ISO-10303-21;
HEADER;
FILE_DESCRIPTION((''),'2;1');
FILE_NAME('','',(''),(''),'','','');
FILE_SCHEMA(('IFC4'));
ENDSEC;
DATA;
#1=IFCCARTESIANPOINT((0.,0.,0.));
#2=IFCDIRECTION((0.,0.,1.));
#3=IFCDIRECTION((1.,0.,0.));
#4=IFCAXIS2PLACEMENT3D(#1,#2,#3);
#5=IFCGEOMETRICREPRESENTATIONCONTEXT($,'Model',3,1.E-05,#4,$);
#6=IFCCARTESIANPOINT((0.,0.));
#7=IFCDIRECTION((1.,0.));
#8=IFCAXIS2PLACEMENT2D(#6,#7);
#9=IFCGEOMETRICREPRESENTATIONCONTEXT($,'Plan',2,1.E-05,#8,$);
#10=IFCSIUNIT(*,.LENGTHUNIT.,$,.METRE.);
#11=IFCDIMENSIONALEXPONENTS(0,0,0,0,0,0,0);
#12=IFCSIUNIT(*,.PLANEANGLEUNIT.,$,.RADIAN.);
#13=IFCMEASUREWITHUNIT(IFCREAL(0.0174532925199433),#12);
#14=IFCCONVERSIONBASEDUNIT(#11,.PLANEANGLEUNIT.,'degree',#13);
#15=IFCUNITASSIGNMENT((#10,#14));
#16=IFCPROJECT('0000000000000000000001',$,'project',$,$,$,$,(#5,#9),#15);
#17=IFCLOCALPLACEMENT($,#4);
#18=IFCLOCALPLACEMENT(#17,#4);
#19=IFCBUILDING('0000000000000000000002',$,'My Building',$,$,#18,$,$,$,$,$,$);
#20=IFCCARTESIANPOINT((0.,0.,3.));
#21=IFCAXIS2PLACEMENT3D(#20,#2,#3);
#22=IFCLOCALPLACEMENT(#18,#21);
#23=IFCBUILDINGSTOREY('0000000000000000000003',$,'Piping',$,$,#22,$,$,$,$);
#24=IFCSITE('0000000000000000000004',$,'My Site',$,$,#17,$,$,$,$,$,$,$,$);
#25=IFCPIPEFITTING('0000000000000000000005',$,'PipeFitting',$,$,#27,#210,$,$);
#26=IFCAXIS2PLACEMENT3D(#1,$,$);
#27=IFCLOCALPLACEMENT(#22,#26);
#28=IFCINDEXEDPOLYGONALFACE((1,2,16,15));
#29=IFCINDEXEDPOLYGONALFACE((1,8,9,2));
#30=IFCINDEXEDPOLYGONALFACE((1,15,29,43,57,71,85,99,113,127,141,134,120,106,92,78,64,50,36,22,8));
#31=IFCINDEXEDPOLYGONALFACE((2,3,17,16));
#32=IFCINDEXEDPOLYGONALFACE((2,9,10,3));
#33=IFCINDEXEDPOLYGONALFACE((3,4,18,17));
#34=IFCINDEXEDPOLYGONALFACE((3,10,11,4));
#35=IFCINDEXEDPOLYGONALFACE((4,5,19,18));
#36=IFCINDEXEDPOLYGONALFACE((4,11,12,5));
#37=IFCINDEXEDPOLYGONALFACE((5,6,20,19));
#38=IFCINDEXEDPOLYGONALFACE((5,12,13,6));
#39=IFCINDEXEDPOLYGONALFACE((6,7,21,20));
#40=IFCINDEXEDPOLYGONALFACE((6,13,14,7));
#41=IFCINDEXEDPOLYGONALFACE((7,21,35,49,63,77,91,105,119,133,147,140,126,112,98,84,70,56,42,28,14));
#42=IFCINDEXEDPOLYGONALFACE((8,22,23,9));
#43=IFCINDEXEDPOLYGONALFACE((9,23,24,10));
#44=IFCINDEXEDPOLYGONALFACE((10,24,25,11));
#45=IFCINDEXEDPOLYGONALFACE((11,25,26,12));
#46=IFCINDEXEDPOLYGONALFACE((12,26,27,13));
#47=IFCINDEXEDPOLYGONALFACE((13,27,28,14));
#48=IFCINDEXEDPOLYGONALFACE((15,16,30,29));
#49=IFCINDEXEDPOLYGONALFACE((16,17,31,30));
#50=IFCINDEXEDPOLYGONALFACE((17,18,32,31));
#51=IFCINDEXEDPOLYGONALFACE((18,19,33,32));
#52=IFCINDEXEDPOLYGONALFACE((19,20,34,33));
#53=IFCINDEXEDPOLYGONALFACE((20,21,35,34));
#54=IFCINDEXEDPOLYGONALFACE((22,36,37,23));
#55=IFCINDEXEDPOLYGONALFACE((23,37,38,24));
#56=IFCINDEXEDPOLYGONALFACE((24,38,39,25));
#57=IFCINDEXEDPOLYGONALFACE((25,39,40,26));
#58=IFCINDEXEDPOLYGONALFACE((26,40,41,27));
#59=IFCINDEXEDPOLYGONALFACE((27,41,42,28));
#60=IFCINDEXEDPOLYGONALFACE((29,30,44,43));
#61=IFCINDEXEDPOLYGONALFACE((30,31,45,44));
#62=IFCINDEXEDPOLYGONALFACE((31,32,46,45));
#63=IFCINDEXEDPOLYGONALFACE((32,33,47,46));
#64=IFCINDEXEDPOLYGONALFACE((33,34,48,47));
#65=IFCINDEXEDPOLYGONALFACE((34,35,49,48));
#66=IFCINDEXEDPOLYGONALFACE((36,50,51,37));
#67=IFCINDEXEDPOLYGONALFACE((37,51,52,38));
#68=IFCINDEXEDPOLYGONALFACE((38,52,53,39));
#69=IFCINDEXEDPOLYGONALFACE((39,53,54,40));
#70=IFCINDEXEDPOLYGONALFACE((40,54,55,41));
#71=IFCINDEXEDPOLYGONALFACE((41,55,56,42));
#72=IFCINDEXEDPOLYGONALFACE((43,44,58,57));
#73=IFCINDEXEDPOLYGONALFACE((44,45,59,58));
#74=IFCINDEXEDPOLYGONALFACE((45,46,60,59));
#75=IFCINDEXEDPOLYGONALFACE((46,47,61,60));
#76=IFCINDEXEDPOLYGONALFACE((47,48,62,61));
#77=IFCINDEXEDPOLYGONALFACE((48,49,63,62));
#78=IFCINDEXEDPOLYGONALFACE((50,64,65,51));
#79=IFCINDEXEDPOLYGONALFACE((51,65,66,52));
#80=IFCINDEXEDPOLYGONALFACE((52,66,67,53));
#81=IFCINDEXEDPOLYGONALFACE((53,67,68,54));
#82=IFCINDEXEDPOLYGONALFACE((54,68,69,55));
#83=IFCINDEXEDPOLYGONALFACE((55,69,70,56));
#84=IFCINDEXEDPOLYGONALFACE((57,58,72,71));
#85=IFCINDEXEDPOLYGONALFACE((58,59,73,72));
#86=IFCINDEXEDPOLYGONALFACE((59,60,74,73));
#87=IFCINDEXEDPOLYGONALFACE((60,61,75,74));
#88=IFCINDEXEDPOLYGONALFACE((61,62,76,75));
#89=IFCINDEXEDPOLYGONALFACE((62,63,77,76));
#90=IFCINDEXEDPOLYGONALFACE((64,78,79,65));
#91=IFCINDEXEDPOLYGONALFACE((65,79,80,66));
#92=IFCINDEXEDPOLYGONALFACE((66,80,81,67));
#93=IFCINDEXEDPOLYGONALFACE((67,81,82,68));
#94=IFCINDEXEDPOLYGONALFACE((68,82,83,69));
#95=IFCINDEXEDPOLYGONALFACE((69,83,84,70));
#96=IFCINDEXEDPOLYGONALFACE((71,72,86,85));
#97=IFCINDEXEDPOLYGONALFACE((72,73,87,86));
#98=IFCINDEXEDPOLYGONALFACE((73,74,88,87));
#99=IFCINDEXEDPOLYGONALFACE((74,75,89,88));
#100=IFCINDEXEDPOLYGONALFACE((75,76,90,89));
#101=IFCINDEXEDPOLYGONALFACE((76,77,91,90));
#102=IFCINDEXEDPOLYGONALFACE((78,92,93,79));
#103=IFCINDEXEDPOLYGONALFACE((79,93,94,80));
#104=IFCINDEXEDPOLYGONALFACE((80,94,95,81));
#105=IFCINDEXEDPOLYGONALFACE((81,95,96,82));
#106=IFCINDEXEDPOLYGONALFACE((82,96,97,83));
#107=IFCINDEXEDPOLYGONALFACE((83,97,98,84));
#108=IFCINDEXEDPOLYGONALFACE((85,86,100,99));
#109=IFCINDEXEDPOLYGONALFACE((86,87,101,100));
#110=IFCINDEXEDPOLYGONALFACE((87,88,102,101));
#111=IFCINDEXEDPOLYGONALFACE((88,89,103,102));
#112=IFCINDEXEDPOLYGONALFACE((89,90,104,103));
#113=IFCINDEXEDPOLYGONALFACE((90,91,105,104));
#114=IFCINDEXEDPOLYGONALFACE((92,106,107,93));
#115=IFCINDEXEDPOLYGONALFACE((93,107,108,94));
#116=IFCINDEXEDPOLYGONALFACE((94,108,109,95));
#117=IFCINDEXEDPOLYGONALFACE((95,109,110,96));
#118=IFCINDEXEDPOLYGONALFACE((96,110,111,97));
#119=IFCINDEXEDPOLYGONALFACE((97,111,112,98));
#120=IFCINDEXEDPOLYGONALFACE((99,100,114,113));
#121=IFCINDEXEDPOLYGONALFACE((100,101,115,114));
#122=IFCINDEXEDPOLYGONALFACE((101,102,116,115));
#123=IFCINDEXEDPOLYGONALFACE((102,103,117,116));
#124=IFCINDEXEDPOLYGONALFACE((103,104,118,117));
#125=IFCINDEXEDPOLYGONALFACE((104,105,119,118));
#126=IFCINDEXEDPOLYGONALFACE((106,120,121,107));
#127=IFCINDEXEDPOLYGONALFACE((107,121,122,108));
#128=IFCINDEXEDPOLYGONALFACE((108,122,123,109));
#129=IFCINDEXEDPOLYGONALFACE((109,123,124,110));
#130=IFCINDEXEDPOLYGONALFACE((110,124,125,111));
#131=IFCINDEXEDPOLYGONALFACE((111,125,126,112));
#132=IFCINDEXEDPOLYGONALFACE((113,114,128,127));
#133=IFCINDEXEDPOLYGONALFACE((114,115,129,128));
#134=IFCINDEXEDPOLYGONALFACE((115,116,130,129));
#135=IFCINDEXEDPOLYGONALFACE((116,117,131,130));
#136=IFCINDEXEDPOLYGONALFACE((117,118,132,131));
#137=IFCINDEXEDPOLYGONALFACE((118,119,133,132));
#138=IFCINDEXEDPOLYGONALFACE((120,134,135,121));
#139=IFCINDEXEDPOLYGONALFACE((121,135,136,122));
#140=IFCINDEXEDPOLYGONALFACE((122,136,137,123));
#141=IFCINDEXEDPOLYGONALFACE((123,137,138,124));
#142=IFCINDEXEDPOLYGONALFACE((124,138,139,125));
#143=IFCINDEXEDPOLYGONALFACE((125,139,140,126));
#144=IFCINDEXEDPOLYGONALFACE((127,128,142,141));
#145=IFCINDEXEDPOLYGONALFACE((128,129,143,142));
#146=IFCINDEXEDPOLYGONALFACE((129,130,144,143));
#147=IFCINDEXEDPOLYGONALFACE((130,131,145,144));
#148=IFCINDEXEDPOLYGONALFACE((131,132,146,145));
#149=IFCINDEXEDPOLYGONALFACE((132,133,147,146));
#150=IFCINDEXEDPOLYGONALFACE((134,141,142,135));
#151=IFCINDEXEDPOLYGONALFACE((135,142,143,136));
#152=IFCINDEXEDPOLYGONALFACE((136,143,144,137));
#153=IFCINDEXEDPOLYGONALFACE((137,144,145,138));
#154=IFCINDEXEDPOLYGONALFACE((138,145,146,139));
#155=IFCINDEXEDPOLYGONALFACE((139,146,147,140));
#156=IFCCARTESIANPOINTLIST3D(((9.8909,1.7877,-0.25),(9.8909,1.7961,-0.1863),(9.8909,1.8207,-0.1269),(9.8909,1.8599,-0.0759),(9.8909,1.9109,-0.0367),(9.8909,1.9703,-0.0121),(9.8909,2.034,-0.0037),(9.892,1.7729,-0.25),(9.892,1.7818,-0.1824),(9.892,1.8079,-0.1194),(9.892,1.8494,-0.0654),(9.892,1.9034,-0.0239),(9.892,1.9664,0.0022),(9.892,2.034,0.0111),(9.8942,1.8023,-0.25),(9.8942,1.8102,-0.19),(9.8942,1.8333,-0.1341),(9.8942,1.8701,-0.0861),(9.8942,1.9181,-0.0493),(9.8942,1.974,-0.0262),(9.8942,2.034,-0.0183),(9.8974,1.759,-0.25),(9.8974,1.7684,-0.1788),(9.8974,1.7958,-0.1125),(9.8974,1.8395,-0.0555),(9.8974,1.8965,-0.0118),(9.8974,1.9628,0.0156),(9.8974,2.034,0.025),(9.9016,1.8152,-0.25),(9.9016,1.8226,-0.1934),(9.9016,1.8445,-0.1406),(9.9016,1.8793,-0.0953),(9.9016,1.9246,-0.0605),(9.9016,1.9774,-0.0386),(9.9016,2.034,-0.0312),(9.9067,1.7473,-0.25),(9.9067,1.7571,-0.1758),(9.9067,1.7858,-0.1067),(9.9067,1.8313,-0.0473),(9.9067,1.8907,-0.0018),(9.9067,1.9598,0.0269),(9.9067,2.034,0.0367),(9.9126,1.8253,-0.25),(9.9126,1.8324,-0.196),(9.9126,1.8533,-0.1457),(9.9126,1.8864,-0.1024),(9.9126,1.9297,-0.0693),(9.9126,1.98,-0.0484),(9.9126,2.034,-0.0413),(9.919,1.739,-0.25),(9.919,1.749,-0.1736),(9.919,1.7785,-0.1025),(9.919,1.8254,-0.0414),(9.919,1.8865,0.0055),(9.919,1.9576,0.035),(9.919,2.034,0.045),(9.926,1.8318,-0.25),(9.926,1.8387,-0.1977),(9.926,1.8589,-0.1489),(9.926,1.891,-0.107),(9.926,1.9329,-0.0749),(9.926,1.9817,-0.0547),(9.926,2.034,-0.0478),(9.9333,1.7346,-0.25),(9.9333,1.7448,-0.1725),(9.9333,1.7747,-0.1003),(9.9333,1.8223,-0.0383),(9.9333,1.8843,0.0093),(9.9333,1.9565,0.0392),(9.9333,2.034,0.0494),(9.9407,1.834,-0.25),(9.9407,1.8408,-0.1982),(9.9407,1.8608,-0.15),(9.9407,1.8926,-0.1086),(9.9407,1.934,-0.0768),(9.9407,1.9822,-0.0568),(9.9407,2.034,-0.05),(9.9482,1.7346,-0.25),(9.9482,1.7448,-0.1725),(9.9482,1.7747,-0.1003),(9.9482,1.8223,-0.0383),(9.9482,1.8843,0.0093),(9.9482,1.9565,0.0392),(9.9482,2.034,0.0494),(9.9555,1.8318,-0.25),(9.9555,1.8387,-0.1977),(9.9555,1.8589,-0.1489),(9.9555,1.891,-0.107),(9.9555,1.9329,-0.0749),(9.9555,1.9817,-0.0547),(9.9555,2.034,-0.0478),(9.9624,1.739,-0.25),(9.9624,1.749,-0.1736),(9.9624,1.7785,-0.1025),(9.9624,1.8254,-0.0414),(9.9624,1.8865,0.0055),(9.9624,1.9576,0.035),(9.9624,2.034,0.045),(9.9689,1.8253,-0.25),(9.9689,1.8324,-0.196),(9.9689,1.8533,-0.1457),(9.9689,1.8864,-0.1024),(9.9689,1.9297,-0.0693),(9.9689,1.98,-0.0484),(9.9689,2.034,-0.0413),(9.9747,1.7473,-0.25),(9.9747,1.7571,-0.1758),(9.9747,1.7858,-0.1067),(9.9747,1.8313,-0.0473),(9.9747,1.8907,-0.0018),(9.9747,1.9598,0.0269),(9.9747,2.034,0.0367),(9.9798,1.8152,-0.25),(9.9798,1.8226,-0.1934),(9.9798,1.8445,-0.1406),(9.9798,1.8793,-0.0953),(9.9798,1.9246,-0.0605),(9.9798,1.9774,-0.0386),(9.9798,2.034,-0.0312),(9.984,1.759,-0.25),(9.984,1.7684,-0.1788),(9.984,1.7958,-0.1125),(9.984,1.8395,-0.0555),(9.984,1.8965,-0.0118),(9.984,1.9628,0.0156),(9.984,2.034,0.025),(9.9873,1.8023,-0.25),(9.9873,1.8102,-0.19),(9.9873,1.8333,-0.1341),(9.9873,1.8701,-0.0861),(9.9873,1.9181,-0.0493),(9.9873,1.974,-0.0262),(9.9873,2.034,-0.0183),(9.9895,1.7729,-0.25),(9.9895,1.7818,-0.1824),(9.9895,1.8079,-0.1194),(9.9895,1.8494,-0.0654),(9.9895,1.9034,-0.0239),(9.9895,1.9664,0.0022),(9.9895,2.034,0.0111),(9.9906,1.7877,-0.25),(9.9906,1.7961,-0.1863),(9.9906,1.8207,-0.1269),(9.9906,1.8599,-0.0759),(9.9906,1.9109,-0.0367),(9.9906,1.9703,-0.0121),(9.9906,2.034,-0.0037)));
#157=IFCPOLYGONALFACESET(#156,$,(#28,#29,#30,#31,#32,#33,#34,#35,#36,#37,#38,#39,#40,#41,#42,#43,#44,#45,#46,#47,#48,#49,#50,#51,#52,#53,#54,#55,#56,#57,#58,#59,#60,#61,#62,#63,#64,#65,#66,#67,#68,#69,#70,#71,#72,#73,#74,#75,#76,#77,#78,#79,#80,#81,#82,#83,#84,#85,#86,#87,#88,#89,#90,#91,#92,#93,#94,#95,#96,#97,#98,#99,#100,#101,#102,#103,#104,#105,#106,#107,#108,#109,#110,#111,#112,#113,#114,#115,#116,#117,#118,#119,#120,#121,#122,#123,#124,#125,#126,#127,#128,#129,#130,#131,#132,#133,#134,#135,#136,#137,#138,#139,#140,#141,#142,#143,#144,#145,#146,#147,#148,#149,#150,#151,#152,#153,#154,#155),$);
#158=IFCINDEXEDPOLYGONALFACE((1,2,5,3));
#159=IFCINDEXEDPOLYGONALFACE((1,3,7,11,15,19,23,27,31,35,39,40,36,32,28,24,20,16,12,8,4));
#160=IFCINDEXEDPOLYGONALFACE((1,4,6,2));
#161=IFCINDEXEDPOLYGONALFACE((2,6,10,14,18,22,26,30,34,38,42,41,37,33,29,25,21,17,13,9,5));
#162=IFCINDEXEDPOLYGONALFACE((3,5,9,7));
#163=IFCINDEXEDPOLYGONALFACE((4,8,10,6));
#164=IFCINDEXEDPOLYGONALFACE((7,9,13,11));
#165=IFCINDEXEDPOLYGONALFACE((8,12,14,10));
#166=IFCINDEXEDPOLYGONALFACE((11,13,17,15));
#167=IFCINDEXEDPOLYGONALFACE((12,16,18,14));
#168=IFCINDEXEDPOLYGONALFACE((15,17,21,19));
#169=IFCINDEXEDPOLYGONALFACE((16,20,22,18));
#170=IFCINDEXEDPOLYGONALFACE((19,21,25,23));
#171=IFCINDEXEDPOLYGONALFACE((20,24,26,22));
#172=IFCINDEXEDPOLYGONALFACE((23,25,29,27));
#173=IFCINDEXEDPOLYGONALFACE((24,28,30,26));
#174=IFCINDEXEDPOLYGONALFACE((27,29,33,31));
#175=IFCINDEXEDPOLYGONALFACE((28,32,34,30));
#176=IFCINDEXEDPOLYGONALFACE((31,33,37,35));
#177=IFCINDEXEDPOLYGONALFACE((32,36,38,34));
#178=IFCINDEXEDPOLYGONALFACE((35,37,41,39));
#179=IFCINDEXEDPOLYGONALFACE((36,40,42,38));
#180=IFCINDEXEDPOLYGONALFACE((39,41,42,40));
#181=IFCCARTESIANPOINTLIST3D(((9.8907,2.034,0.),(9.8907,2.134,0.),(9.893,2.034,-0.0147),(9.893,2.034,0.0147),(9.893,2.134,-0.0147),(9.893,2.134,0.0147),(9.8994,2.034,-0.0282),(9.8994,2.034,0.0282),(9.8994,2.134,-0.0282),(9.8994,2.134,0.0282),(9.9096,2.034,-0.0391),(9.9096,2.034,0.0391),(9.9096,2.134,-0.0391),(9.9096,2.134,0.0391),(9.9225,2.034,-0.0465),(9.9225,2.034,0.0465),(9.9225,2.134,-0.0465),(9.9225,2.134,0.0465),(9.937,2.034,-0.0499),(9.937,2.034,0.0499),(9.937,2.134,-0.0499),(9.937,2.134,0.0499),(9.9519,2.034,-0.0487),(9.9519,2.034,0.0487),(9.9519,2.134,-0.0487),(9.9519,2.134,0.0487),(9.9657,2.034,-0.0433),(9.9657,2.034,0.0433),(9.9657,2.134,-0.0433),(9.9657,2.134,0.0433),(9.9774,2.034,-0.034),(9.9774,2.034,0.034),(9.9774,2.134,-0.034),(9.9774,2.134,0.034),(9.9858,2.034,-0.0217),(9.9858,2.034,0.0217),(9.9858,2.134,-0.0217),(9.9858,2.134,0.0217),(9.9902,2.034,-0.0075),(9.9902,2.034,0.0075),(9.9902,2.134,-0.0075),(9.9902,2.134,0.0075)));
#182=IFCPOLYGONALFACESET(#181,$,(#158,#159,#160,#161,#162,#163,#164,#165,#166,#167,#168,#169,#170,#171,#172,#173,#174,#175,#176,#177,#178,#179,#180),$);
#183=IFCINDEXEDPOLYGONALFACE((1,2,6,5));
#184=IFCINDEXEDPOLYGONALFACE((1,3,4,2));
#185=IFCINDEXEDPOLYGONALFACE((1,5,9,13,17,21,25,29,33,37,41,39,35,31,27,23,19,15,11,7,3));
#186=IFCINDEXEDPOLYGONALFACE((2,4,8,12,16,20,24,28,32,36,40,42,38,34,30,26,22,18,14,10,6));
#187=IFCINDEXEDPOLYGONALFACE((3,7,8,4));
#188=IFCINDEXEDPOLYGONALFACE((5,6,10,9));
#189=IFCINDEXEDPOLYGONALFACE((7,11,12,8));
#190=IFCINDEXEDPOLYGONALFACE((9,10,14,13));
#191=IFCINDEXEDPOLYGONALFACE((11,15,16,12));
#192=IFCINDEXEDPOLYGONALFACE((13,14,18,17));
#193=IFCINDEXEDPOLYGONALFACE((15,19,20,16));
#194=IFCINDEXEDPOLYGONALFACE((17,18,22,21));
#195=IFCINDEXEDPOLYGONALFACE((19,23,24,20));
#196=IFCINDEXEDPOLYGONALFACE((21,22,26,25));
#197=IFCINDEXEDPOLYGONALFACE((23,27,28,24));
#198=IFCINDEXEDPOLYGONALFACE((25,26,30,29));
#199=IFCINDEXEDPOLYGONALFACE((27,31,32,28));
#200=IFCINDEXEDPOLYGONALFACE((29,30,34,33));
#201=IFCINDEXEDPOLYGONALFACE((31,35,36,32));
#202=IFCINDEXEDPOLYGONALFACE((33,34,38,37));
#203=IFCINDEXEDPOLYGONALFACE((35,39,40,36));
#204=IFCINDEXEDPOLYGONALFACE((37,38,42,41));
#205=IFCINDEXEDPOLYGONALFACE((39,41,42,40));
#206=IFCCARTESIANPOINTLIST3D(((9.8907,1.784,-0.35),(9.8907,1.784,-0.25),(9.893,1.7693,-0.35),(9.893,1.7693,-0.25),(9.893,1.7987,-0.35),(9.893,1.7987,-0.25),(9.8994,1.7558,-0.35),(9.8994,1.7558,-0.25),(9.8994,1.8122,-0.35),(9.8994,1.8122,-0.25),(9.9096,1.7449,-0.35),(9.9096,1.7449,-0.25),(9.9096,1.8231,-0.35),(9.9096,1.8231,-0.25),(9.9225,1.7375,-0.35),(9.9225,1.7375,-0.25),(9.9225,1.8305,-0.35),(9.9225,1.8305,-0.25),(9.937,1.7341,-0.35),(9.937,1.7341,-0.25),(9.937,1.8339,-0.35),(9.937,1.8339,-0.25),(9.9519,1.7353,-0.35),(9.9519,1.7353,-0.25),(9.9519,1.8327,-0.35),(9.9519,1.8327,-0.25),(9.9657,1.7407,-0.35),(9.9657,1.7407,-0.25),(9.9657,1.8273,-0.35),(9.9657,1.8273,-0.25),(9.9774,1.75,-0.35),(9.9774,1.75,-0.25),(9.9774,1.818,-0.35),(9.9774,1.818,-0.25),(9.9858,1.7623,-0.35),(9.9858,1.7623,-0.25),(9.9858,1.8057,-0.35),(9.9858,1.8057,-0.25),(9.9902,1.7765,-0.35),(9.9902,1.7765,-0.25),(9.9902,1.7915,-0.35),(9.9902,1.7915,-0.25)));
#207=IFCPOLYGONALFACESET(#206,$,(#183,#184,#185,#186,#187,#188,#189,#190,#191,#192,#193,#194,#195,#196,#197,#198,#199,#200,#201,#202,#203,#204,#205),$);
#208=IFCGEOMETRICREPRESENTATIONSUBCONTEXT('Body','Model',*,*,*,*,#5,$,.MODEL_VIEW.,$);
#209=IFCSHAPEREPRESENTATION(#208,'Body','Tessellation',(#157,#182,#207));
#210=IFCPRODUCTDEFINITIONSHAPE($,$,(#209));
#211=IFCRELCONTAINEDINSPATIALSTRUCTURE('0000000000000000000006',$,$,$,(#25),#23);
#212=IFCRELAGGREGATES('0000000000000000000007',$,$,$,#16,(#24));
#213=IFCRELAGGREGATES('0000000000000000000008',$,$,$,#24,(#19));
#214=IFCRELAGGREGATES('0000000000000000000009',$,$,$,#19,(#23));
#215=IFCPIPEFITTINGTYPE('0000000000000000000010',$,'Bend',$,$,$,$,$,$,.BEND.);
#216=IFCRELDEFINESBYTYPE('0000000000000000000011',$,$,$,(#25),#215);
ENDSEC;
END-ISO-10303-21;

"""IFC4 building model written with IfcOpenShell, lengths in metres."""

from ifc_helpers import new_model, entity, si_unit, converted_unit, frame, origin_with_axes, origin_2d_with_axis, place, context, subcontext, project, spatial, circle, extrude, source, transform, mapped, type_object, type_shapes, element, save


model = new_model("IFC4")

# Units and contexts
model_context = context("Model", 3, precision=1e-05, world=origin_with_axes())
plan_context = context("Plan", 2, precision=1e-05, world=origin_2d_with_axis())
body_context = subcontext(model_context, "Body", "Model", "MODEL_VIEW")
ifc_project = project(units=[si_unit("LENGTHUNIT", "METRE"), converted_unit("PLANEANGLEUNIT", "degree", entity("IfcReal", 0.0174532925199433), si_unit("PLANEANGLEUNIT", "RADIAN"), dimensions=[0, 0, 0, 0, 0, 0, 0])], contexts=[model_context, plan_context])

# Site, building, storey
site_placement = place(None, origin_with_axes())
site = spatial("IfcSite", under=ifc_project, at=site_placement, Name="My Site")
building_placement = place(site_placement, origin_with_axes())
building = spatial("IfcBuilding", under=site, at=building_placement, Name="My Building")
storey_placement = place(building_placement, frame((0.0, 0.0, 3.0), z_axis=(0.0, 0.0, 1.0), x_axis=(1.0, 0.0, 0.0)))
storey = spatial("IfcBuildingStorey", under=building, at=storey_placement, Name="Piping")

# Pipe fitting
pipe_fitting_type_1 = type_object("IfcPipeFittingType", Name="Bend", PredefinedType="BEND")
shared_shape = source(origin_with_axes(), body_context, "Body", "SolidModel", [
    entity("IfcSweptDiskSolid", entity("IfcIndexedPolyCurve", entity("IfcCartesianPointList3D", [[0.0, 0.0, -0.1], [0.0, -0.0732, -0.2768], [0.0, -0.25, -0.35]]), [entity("IfcArcIndex", [1, 2, 3])]), 0.05),
    extrude(circle(Radius=0.05), origin_with_axes(), (0.0, 0.0, -1.0), 0.1),
    extrude(circle(Radius=0.05), frame((0.0, -0.25, -0.35), z_axis=(0.0, -1.0, 0.0), x_axis=(1.0, 0.0, 0.0)), (0.0, 0.0, 1.0), 0.1),
])
type_shapes(pipe_fitting_type_1, [shared_shape])
for number, where, z_axis, x_axis, name in (
    (1, (9.9407, 2.134, 0.0), (0.0, 1.0, 0.0), (-1.0, 0.0, 0.0), "PipeFitting"),
):
    element("IfcPipeFitting", number, at=place(storey_placement, frame(where, z_axis=z_axis, x_axis=x_axis)), inside=storey, type_object=pipe_fitting_type_1, Name=name, context=body_context, shape_type="MappedRepresentation", body=[
        mapped(shared_shape, transform((0.0, 0.0, 0.0), x_axis=(1.0, 0.0, 0.0), y_axis=(0.0, 1.0, 0.0), z_axis=(0.0, 0.0, 1.0), scale=1.0)),
    ])

save(model, "model.ifc")
